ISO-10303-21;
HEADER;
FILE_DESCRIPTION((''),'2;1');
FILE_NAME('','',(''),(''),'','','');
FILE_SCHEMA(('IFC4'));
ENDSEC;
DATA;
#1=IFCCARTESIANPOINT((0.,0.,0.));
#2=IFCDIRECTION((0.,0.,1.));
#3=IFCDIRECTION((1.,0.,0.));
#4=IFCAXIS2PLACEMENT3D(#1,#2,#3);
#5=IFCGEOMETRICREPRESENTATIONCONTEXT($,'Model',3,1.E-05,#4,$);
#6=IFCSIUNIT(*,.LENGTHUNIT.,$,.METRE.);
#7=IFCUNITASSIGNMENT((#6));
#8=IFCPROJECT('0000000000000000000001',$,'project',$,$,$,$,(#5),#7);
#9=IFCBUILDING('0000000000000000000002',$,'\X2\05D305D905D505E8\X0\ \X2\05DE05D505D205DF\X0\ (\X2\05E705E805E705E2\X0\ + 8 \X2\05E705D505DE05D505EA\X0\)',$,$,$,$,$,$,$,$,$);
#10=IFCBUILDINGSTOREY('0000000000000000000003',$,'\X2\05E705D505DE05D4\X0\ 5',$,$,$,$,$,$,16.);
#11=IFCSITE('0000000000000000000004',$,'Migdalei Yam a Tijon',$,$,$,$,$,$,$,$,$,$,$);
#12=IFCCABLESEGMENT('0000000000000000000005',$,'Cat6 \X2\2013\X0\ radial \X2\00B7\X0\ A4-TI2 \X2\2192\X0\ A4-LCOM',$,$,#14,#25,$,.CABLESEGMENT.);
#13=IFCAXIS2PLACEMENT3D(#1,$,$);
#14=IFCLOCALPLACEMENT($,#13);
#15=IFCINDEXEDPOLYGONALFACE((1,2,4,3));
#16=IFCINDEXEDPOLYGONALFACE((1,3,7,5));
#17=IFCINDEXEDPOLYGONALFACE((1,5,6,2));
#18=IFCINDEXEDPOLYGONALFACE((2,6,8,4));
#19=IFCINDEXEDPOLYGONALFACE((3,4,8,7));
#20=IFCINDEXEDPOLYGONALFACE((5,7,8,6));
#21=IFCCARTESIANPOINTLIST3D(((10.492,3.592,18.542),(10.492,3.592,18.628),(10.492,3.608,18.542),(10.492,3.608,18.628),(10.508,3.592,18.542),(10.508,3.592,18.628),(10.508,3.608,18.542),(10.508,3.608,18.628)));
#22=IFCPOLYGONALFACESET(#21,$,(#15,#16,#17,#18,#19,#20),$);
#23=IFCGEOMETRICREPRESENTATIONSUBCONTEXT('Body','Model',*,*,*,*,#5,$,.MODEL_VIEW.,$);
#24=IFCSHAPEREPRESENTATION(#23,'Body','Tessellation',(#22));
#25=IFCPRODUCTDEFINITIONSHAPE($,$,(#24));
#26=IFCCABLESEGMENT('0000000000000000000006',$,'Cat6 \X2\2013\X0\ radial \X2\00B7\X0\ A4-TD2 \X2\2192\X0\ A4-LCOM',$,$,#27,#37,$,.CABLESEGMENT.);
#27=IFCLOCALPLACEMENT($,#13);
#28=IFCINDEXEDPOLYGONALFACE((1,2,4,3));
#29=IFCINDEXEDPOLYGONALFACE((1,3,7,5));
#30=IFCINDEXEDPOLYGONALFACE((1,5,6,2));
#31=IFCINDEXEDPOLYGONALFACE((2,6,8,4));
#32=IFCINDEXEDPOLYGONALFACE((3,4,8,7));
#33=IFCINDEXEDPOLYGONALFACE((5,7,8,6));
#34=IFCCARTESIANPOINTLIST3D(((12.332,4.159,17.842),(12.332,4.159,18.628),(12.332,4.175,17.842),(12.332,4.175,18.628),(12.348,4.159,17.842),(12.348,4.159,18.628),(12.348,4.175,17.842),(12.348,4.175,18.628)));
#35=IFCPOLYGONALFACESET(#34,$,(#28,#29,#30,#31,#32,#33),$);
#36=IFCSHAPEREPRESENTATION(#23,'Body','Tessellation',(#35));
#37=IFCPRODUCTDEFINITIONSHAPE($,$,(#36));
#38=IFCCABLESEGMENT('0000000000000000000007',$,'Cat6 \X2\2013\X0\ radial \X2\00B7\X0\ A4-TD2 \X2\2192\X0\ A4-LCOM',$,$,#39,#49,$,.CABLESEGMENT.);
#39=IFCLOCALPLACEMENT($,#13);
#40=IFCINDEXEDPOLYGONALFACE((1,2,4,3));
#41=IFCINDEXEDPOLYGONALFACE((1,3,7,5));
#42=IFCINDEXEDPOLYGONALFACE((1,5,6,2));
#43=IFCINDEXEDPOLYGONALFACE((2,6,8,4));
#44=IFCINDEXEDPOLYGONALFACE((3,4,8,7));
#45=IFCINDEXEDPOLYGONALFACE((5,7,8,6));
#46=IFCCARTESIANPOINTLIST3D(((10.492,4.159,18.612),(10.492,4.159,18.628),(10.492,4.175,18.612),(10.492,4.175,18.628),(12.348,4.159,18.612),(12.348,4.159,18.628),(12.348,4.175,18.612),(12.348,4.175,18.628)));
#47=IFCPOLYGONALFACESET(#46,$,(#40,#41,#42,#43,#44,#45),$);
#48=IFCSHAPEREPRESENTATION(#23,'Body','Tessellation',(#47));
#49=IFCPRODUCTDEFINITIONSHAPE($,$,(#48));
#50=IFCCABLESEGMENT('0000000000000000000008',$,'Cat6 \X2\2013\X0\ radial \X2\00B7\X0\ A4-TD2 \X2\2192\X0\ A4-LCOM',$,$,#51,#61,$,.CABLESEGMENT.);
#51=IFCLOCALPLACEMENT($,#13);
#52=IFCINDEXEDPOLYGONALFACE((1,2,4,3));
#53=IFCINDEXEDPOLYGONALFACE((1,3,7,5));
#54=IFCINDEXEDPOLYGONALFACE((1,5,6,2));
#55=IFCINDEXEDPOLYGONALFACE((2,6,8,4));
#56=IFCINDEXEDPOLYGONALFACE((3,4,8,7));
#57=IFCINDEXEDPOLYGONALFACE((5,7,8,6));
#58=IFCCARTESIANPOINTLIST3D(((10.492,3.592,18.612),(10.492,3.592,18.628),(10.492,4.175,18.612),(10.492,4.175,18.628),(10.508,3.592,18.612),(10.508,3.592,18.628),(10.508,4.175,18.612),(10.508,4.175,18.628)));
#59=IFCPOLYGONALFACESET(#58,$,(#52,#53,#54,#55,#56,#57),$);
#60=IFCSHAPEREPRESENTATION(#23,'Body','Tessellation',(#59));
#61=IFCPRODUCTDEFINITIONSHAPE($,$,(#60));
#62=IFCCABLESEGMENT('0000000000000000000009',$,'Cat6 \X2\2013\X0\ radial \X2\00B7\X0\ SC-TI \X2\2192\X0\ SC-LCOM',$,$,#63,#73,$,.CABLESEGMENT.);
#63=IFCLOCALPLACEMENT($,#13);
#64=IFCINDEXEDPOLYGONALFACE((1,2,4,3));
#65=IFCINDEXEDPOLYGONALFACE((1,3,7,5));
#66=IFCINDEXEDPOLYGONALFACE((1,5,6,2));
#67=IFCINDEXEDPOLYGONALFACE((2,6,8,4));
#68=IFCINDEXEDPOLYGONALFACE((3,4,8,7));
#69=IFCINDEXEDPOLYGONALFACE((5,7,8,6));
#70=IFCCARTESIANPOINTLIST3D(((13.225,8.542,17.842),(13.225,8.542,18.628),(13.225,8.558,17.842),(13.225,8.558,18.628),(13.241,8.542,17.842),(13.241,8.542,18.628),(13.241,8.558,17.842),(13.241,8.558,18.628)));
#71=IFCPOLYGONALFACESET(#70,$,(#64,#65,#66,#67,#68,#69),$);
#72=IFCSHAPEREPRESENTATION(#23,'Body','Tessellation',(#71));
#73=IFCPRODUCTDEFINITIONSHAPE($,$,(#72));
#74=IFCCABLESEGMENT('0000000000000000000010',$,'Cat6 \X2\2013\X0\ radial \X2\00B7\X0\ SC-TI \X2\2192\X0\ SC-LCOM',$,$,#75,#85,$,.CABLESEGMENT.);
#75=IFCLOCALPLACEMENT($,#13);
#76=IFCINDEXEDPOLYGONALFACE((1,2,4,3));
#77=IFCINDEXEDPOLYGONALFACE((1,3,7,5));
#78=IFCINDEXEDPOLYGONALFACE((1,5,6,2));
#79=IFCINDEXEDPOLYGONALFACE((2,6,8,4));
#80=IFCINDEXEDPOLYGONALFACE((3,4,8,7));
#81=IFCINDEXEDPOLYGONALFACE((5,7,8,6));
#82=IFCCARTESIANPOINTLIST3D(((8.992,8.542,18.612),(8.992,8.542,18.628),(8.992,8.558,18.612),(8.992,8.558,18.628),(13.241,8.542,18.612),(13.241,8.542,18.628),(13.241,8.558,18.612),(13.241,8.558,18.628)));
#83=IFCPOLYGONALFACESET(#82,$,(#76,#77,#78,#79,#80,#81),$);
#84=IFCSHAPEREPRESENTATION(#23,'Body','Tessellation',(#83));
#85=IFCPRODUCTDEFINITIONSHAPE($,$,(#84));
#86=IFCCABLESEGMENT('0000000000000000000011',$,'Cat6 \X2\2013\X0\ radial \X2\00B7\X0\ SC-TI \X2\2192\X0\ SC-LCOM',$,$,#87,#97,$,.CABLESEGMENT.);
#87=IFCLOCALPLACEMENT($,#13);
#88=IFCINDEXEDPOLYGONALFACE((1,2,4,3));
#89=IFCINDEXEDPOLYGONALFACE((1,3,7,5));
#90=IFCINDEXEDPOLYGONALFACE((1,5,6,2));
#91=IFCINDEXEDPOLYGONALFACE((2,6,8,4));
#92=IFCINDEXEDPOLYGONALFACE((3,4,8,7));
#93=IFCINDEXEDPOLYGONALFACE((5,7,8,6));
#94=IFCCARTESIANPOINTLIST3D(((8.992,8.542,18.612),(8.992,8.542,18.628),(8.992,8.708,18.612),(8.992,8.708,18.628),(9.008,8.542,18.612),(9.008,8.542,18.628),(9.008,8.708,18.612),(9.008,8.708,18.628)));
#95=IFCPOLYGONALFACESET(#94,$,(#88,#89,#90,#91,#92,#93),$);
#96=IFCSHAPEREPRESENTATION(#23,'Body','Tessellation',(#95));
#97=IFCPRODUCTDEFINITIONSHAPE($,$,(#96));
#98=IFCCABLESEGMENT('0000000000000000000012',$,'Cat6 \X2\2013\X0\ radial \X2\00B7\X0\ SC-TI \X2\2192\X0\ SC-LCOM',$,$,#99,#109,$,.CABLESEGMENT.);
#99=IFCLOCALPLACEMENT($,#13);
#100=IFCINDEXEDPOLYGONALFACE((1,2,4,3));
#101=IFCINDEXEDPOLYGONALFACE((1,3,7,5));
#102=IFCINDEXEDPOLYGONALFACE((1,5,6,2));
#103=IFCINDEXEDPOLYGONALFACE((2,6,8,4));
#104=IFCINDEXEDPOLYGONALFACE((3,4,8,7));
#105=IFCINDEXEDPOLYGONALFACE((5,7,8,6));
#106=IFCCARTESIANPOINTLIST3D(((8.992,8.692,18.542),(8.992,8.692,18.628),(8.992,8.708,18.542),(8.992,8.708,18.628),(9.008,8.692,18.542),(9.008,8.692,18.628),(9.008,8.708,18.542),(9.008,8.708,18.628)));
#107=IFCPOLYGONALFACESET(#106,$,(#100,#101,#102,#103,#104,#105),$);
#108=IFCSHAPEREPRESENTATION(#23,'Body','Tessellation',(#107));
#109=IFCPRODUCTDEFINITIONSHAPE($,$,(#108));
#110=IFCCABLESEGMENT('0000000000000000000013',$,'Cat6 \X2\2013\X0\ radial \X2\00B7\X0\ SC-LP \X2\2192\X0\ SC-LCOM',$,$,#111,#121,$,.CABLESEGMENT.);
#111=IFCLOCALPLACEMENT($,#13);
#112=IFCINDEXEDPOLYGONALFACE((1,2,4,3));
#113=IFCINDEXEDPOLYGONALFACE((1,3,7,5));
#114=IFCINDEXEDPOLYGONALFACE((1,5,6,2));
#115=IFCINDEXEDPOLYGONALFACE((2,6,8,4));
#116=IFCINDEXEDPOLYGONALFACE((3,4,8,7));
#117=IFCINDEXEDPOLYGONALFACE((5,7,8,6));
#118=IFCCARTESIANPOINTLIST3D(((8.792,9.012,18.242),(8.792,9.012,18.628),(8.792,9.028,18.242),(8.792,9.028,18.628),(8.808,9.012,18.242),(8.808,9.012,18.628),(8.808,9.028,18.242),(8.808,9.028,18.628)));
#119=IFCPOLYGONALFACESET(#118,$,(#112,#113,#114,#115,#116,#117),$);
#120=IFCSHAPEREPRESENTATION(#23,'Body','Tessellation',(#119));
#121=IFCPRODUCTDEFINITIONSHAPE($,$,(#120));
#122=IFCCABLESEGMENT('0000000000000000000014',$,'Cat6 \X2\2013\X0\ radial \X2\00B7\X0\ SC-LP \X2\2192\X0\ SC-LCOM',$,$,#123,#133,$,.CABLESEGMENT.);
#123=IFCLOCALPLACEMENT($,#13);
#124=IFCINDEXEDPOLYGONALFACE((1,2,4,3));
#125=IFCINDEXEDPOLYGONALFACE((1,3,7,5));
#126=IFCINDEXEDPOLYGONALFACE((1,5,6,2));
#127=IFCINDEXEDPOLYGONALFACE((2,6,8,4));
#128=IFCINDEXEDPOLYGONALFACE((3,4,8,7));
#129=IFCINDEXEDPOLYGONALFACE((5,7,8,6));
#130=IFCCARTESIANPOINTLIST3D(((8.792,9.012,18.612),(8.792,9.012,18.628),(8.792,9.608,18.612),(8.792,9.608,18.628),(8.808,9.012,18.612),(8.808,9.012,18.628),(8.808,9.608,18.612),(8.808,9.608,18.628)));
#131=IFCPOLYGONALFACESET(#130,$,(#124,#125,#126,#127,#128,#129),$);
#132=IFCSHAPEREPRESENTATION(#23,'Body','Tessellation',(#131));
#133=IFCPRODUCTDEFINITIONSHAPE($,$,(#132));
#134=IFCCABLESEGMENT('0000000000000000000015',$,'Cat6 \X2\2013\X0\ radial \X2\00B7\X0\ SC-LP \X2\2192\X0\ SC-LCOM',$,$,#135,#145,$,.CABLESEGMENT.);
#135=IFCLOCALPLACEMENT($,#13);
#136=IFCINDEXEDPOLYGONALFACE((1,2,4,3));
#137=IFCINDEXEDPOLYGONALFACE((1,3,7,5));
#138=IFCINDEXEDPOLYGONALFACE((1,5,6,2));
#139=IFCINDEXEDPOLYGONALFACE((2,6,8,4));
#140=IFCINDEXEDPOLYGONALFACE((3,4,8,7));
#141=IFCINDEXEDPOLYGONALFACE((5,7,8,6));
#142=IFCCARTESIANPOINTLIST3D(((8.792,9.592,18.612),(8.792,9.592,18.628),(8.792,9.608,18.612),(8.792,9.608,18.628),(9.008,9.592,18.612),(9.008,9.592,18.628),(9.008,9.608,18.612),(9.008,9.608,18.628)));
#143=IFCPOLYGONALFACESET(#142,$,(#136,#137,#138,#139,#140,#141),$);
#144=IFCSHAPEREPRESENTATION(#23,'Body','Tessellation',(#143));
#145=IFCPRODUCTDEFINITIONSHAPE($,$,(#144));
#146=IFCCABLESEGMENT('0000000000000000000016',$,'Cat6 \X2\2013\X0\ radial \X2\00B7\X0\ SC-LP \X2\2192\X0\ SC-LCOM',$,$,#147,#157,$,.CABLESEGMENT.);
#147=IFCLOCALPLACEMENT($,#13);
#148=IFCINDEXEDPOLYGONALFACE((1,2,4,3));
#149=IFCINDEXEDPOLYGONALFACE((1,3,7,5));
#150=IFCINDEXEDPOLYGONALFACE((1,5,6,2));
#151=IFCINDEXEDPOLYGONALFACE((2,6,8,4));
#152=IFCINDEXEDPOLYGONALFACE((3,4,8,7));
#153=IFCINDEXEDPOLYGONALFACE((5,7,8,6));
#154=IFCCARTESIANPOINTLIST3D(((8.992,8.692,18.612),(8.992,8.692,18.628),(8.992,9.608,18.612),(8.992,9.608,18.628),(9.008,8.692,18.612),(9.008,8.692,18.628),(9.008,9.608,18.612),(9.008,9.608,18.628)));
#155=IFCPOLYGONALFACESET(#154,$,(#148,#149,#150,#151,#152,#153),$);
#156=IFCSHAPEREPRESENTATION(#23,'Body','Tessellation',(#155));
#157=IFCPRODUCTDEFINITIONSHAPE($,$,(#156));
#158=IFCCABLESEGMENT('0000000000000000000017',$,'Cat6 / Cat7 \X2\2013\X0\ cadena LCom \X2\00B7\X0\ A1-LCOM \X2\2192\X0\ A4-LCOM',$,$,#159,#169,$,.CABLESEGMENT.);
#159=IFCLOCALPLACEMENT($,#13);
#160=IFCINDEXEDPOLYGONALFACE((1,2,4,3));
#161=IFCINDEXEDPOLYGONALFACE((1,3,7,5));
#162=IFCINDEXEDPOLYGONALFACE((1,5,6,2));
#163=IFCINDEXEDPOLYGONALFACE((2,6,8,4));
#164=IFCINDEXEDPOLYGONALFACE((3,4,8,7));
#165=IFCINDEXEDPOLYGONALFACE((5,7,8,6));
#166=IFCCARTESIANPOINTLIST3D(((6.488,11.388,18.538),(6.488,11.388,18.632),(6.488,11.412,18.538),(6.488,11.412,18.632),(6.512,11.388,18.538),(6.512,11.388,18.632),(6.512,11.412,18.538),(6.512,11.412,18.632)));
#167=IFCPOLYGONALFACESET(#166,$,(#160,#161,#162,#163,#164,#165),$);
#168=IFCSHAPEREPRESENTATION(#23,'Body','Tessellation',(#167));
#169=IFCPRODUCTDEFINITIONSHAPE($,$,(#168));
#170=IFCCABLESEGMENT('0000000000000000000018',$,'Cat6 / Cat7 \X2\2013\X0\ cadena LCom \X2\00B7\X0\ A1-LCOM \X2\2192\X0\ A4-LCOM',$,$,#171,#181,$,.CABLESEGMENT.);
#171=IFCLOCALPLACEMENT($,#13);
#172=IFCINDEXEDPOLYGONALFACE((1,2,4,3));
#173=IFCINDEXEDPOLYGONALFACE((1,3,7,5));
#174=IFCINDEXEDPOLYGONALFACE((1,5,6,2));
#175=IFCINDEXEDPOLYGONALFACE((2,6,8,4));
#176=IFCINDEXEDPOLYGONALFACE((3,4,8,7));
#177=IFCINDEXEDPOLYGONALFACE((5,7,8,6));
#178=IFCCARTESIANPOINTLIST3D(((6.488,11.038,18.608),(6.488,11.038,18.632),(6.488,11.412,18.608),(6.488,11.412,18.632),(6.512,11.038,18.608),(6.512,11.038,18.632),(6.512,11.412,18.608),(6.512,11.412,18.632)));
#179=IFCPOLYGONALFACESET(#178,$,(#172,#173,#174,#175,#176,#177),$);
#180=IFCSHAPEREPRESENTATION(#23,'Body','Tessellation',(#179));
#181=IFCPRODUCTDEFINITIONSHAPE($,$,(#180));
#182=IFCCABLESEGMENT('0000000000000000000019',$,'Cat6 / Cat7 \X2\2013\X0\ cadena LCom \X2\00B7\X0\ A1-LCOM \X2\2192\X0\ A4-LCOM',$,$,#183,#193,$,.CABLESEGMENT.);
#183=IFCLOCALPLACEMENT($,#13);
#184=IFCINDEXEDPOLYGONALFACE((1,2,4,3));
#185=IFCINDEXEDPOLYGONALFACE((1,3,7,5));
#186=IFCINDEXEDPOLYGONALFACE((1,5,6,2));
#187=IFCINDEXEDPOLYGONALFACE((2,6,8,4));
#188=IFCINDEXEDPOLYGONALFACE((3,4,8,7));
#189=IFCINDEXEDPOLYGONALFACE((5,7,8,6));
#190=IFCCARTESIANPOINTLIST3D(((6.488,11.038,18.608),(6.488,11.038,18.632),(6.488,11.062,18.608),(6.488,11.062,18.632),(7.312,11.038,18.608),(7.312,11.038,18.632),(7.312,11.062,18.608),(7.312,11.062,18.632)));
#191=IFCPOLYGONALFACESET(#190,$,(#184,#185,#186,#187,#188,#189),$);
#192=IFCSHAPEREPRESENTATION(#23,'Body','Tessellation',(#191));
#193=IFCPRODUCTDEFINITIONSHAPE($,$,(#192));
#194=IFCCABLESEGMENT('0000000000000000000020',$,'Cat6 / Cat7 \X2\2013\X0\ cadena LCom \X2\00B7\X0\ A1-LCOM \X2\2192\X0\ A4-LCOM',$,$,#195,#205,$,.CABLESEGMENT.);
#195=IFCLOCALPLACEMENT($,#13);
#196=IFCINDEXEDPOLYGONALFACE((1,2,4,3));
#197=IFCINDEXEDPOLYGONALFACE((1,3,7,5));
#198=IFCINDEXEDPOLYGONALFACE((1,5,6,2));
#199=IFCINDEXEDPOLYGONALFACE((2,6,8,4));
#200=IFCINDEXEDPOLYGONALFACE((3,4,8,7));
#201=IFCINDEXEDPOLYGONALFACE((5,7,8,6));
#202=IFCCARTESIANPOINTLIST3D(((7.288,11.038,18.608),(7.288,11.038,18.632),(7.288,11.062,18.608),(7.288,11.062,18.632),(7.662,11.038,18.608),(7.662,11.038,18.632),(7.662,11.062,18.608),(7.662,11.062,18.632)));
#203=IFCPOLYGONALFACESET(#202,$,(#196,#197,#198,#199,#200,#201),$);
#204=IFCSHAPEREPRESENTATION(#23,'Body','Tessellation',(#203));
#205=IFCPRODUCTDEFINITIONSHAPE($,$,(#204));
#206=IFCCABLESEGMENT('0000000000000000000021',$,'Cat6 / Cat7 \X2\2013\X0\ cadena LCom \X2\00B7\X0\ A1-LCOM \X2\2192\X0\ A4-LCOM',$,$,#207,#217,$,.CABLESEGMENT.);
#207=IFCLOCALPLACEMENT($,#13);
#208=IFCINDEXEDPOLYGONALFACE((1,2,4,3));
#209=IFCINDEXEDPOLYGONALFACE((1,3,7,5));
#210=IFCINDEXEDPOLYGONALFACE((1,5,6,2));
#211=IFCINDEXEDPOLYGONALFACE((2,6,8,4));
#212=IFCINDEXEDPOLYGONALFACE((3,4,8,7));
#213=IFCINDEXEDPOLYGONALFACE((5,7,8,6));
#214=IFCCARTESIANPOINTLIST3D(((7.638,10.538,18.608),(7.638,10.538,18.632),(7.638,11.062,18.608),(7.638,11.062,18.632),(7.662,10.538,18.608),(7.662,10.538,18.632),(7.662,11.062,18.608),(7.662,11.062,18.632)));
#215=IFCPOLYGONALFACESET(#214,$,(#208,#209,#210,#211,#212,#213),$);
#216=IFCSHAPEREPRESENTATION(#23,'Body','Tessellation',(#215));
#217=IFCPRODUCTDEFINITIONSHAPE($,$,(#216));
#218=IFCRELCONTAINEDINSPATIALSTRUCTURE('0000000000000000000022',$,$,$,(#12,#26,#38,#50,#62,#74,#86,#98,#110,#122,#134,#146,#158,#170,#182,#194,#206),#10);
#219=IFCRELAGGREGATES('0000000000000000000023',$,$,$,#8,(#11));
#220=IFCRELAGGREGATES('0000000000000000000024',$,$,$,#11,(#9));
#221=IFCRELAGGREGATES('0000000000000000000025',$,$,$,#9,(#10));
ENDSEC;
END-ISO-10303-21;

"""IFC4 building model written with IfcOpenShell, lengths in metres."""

from ifc_helpers import new_model, si_unit, frame, origin_with_axes, context, subcontext, project, spatial, line, indexed_curve, outline, extrude, element, save


model = new_model("IFC4")

# Units and contexts
model_context = context("Model", 3, precision=1e-05, world=origin_with_axes())
body_context = subcontext(model_context, "Body", "Model", "MODEL_VIEW")
ifc_project = project(units=[si_unit("LENGTHUNIT", "METRE")], contexts=[model_context])

# Site, building, storey
site = spatial("IfcSite", under=ifc_project, Name="Migdalei Yam a Tijon")
building = spatial("IfcBuilding", under=site, Name="דיור מוגן (קרקע + 8 קומות)")
storey = spatial("IfcBuildingStorey", under=building, Name="קומה 5", Elevation=16.0)

# Cable segments
element("IfcCableSegment", 1, inside=storey, Name="Cat6 – radial · A4-TI2 → A4-LCOM", PredefinedType="CABLESEGMENT", context=body_context, shape_type="SweptSolid", body=[
    extrude(outline(indexed_curve([(0.0, 0.0), (0.016, 0.0), (0.016, 0.016), (0.0, 0.016)], segments=[line(1, 2, 3, 4, 1)])), frame((10.492, 3.592, 18.542), z_axis=(0.0, 0.0, 1.0), x_axis=(1.0, 0.0, 0.0)), (0.0, 0.0, 1.0), 0.086),
])
element("IfcCableSegment", 2, inside=storey, Name="Cat6 – radial · A4-TD2 → A4-LCOM", PredefinedType="CABLESEGMENT", context=body_context, shape_type="SweptSolid", body=[
    extrude(outline(indexed_curve([(0.0, 0.0), (0.016, 0.0), (0.016, 0.016), (0.0, 0.016)], segments=[line(1, 2, 3, 4, 1)])), frame((12.332, 4.159, 17.842), z_axis=(0.0, 0.0, 1.0), x_axis=(1.0, 0.0, 0.0)), (0.0, 0.0, 1.0), 0.786),
])
element("IfcCableSegment", 3, inside=storey, Name="Cat6 – radial · A4-TD2 → A4-LCOM", PredefinedType="CABLESEGMENT", context=body_context, shape_type="SweptSolid", body=[
    extrude(outline(indexed_curve([(0.0, 0.0), (1.856, 0.0), (1.856, 0.016), (0.0, 0.016)], segments=[line(1, 2, 3, 4, 1)])), frame((10.492, 4.159, 18.612), z_axis=(0.0, 0.0, 1.0), x_axis=(1.0, 0.0, 0.0)), (0.0, 0.0, 1.0), 0.016),
])
element("IfcCableSegment", 4, inside=storey, Name="Cat6 – radial · A4-TD2 → A4-LCOM", PredefinedType="CABLESEGMENT", context=body_context, shape_type="SweptSolid", body=[
    extrude(outline(indexed_curve([(0.0, 0.0), (0.016, 0.0), (0.016, 0.583), (0.0, 0.583)], segments=[line(1, 2, 3, 4, 1)])), frame((10.492, 3.592, 18.612), z_axis=(0.0, 0.0, 1.0), x_axis=(1.0, 0.0, 0.0)), (0.0, 0.0, 1.0), 0.016),
])
element("IfcCableSegment", 5, inside=storey, Name="Cat6 – radial · SC-TI → SC-LCOM", PredefinedType="CABLESEGMENT", context=body_context, shape_type="SweptSolid", body=[
    extrude(outline(indexed_curve([(0.0, 0.0), (0.016, 0.0), (0.016, 0.016), (0.0, 0.016)], segments=[line(1, 2, 3, 4, 1)])), frame((13.225, 8.542, 17.842), z_axis=(0.0, 0.0, 1.0), x_axis=(1.0, 0.0, 0.0)), (0.0, 0.0, 1.0), 0.786),
])
element("IfcCableSegment", 6, inside=storey, Name="Cat6 – radial · SC-TI → SC-LCOM", PredefinedType="CABLESEGMENT", context=body_context, shape_type="SweptSolid", body=[
    extrude(outline(indexed_curve([(0.0, 0.0), (4.249, 0.0), (4.249, 0.016), (0.0, 0.016)], segments=[line(1, 2, 3, 4, 1)])), frame((8.992, 8.542, 18.612), z_axis=(0.0, 0.0, 1.0), x_axis=(1.0, 0.0, 0.0)), (0.0, 0.0, 1.0), 0.016),
])
element("IfcCableSegment", 7, inside=storey, Name="Cat6 – radial · SC-TI → SC-LCOM", PredefinedType="CABLESEGMENT", context=body_context, shape_type="SweptSolid", body=[
    extrude(outline(indexed_curve([(0.0, 0.0), (0.016, 0.0), (0.016, 0.166), (0.0, 0.166)], segments=[line(1, 2, 3, 4, 1)])), frame((8.992, 8.542, 18.612), z_axis=(0.0, 0.0, 1.0), x_axis=(1.0, 0.0, 0.0)), (0.0, 0.0, 1.0), 0.016),
])
element("IfcCableSegment", 8, inside=storey, Name="Cat6 – radial · SC-TI → SC-LCOM", PredefinedType="CABLESEGMENT", context=body_context, shape_type="SweptSolid", body=[
    extrude(outline(indexed_curve([(0.0, 0.0), (0.016, 0.0), (0.016, 0.016), (0.0, 0.016)], segments=[line(1, 2, 3, 4, 1)])), frame((8.992, 8.692, 18.542), z_axis=(0.0, 0.0, 1.0), x_axis=(1.0, 0.0, 0.0)), (0.0, 0.0, 1.0), 0.086),
])
element("IfcCableSegment", 9, inside=storey, Name="Cat6 – radial · SC-LP → SC-LCOM", PredefinedType="CABLESEGMENT", context=body_context, shape_type="SweptSolid", body=[
    extrude(outline(indexed_curve([(0.0, 0.0), (0.016, 0.0), (0.016, 0.016), (0.0, 0.016)], segments=[line(1, 2, 3, 4, 1)])), frame((8.792, 9.012, 18.242), z_axis=(0.0, 0.0, 1.0), x_axis=(1.0, 0.0, 0.0)), (0.0, 0.0, 1.0), 0.386),
])
element("IfcCableSegment", 10, inside=storey, Name="Cat6 – radial · SC-LP → SC-LCOM", PredefinedType="CABLESEGMENT", context=body_context, shape_type="SweptSolid", body=[
    extrude(outline(indexed_curve([(0.0, 0.0), (0.016, 0.0), (0.016, 0.596), (0.0, 0.596)], segments=[line(1, 2, 3, 4, 1)])), frame((8.792, 9.012, 18.612), z_axis=(0.0, 0.0, 1.0), x_axis=(1.0, 0.0, 0.0)), (0.0, 0.0, 1.0), 0.016),
])
element("IfcCableSegment", 11, inside=storey, Name="Cat6 – radial · SC-LP → SC-LCOM", PredefinedType="CABLESEGMENT", context=body_context, shape_type="SweptSolid", body=[
    extrude(outline(indexed_curve([(0.0, 0.0), (0.216, 0.0), (0.216, 0.016), (0.0, 0.016)], segments=[line(1, 2, 3, 4, 1)])), frame((8.792, 9.592, 18.612), z_axis=(0.0, 0.0, 1.0), x_axis=(1.0, 0.0, 0.0)), (0.0, 0.0, 1.0), 0.016),
])
element("IfcCableSegment", 12, inside=storey, Name="Cat6 – radial · SC-LP → SC-LCOM", PredefinedType="CABLESEGMENT", context=body_context, shape_type="SweptSolid", body=[
    extrude(outline(indexed_curve([(0.0, 0.0), (0.016, 0.0), (0.016, 0.916), (0.0, 0.916)], segments=[line(1, 2, 3, 4, 1)])), frame((8.992, 8.692, 18.612), z_axis=(0.0, 0.0, 1.0), x_axis=(1.0, 0.0, 0.0)), (0.0, 0.0, 1.0), 0.016),
])
element("IfcCableSegment", 13, inside=storey, Name="Cat6 / Cat7 – cadena LCom · A1-LCOM → A4-LCOM", PredefinedType="CABLESEGMENT", context=body_context, shape_type="SweptSolid", body=[
    extrude(outline(indexed_curve([(0.0, 0.0), (0.024, 0.0), (0.024, 0.024), (0.0, 0.024)], segments=[line(1, 2, 3, 4, 1)])), frame((6.488, 11.388, 18.538), z_axis=(0.0, 0.0, 1.0), x_axis=(1.0, 0.0, 0.0)), (0.0, 0.0, 1.0), 0.094),
])
element("IfcCableSegment", 14, inside=storey, Name="Cat6 / Cat7 – cadena LCom · A1-LCOM → A4-LCOM", PredefinedType="CABLESEGMENT", context=body_context, shape_type="SweptSolid", body=[
    extrude(outline(indexed_curve([(0.0, 0.0), (0.024, 0.0), (0.024, 0.374), (0.0, 0.374)], segments=[line(1, 2, 3, 4, 1)])), frame((6.488, 11.038, 18.608), z_axis=(0.0, 0.0, 1.0), x_axis=(1.0, 0.0, 0.0)), (0.0, 0.0, 1.0), 0.024),
])
element("IfcCableSegment", 15, inside=storey, Name="Cat6 / Cat7 – cadena LCom · A1-LCOM → A4-LCOM", PredefinedType="CABLESEGMENT", context=body_context, shape_type="SweptSolid", body=[
    extrude(outline(indexed_curve([(0.0, 0.0), (0.824, 0.0), (0.824, 0.024), (0.0, 0.024)], segments=[line(1, 2, 3, 4, 1)])), frame((6.488, 11.038, 18.608), z_axis=(0.0, 0.0, 1.0), x_axis=(1.0, 0.0, 0.0)), (0.0, 0.0, 1.0), 0.024),
])
element("IfcCableSegment", 16, inside=storey, Name="Cat6 / Cat7 – cadena LCom · A1-LCOM → A4-LCOM", PredefinedType="CABLESEGMENT", context=body_context, shape_type="SweptSolid", body=[
    extrude(outline(indexed_curve([(0.0, 0.0), (0.374, 0.0), (0.374, 0.024), (0.0, 0.024)], segments=[line(1, 2, 3, 4, 1)])), frame((7.288, 11.038, 18.608), z_axis=(0.0, 0.0, 1.0), x_axis=(1.0, 0.0, 0.0)), (0.0, 0.0, 1.0), 0.024),
])
element("IfcCableSegment", 17, inside=storey, Name="Cat6 / Cat7 – cadena LCom · A1-LCOM → A4-LCOM", PredefinedType="CABLESEGMENT", context=body_context, shape_type="SweptSolid", body=[
    extrude(outline(indexed_curve([(0.0, 0.0), (0.024, 0.0), (0.024, 0.524), (0.0, 0.524)], segments=[line(1, 2, 3, 4, 1)])), frame((7.638, 10.538, 18.608), z_axis=(0.0, 0.0, 1.0), x_axis=(1.0, 0.0, 0.0)), (0.0, 0.0, 1.0), 0.024),
])

save(model, "model.ifc")
